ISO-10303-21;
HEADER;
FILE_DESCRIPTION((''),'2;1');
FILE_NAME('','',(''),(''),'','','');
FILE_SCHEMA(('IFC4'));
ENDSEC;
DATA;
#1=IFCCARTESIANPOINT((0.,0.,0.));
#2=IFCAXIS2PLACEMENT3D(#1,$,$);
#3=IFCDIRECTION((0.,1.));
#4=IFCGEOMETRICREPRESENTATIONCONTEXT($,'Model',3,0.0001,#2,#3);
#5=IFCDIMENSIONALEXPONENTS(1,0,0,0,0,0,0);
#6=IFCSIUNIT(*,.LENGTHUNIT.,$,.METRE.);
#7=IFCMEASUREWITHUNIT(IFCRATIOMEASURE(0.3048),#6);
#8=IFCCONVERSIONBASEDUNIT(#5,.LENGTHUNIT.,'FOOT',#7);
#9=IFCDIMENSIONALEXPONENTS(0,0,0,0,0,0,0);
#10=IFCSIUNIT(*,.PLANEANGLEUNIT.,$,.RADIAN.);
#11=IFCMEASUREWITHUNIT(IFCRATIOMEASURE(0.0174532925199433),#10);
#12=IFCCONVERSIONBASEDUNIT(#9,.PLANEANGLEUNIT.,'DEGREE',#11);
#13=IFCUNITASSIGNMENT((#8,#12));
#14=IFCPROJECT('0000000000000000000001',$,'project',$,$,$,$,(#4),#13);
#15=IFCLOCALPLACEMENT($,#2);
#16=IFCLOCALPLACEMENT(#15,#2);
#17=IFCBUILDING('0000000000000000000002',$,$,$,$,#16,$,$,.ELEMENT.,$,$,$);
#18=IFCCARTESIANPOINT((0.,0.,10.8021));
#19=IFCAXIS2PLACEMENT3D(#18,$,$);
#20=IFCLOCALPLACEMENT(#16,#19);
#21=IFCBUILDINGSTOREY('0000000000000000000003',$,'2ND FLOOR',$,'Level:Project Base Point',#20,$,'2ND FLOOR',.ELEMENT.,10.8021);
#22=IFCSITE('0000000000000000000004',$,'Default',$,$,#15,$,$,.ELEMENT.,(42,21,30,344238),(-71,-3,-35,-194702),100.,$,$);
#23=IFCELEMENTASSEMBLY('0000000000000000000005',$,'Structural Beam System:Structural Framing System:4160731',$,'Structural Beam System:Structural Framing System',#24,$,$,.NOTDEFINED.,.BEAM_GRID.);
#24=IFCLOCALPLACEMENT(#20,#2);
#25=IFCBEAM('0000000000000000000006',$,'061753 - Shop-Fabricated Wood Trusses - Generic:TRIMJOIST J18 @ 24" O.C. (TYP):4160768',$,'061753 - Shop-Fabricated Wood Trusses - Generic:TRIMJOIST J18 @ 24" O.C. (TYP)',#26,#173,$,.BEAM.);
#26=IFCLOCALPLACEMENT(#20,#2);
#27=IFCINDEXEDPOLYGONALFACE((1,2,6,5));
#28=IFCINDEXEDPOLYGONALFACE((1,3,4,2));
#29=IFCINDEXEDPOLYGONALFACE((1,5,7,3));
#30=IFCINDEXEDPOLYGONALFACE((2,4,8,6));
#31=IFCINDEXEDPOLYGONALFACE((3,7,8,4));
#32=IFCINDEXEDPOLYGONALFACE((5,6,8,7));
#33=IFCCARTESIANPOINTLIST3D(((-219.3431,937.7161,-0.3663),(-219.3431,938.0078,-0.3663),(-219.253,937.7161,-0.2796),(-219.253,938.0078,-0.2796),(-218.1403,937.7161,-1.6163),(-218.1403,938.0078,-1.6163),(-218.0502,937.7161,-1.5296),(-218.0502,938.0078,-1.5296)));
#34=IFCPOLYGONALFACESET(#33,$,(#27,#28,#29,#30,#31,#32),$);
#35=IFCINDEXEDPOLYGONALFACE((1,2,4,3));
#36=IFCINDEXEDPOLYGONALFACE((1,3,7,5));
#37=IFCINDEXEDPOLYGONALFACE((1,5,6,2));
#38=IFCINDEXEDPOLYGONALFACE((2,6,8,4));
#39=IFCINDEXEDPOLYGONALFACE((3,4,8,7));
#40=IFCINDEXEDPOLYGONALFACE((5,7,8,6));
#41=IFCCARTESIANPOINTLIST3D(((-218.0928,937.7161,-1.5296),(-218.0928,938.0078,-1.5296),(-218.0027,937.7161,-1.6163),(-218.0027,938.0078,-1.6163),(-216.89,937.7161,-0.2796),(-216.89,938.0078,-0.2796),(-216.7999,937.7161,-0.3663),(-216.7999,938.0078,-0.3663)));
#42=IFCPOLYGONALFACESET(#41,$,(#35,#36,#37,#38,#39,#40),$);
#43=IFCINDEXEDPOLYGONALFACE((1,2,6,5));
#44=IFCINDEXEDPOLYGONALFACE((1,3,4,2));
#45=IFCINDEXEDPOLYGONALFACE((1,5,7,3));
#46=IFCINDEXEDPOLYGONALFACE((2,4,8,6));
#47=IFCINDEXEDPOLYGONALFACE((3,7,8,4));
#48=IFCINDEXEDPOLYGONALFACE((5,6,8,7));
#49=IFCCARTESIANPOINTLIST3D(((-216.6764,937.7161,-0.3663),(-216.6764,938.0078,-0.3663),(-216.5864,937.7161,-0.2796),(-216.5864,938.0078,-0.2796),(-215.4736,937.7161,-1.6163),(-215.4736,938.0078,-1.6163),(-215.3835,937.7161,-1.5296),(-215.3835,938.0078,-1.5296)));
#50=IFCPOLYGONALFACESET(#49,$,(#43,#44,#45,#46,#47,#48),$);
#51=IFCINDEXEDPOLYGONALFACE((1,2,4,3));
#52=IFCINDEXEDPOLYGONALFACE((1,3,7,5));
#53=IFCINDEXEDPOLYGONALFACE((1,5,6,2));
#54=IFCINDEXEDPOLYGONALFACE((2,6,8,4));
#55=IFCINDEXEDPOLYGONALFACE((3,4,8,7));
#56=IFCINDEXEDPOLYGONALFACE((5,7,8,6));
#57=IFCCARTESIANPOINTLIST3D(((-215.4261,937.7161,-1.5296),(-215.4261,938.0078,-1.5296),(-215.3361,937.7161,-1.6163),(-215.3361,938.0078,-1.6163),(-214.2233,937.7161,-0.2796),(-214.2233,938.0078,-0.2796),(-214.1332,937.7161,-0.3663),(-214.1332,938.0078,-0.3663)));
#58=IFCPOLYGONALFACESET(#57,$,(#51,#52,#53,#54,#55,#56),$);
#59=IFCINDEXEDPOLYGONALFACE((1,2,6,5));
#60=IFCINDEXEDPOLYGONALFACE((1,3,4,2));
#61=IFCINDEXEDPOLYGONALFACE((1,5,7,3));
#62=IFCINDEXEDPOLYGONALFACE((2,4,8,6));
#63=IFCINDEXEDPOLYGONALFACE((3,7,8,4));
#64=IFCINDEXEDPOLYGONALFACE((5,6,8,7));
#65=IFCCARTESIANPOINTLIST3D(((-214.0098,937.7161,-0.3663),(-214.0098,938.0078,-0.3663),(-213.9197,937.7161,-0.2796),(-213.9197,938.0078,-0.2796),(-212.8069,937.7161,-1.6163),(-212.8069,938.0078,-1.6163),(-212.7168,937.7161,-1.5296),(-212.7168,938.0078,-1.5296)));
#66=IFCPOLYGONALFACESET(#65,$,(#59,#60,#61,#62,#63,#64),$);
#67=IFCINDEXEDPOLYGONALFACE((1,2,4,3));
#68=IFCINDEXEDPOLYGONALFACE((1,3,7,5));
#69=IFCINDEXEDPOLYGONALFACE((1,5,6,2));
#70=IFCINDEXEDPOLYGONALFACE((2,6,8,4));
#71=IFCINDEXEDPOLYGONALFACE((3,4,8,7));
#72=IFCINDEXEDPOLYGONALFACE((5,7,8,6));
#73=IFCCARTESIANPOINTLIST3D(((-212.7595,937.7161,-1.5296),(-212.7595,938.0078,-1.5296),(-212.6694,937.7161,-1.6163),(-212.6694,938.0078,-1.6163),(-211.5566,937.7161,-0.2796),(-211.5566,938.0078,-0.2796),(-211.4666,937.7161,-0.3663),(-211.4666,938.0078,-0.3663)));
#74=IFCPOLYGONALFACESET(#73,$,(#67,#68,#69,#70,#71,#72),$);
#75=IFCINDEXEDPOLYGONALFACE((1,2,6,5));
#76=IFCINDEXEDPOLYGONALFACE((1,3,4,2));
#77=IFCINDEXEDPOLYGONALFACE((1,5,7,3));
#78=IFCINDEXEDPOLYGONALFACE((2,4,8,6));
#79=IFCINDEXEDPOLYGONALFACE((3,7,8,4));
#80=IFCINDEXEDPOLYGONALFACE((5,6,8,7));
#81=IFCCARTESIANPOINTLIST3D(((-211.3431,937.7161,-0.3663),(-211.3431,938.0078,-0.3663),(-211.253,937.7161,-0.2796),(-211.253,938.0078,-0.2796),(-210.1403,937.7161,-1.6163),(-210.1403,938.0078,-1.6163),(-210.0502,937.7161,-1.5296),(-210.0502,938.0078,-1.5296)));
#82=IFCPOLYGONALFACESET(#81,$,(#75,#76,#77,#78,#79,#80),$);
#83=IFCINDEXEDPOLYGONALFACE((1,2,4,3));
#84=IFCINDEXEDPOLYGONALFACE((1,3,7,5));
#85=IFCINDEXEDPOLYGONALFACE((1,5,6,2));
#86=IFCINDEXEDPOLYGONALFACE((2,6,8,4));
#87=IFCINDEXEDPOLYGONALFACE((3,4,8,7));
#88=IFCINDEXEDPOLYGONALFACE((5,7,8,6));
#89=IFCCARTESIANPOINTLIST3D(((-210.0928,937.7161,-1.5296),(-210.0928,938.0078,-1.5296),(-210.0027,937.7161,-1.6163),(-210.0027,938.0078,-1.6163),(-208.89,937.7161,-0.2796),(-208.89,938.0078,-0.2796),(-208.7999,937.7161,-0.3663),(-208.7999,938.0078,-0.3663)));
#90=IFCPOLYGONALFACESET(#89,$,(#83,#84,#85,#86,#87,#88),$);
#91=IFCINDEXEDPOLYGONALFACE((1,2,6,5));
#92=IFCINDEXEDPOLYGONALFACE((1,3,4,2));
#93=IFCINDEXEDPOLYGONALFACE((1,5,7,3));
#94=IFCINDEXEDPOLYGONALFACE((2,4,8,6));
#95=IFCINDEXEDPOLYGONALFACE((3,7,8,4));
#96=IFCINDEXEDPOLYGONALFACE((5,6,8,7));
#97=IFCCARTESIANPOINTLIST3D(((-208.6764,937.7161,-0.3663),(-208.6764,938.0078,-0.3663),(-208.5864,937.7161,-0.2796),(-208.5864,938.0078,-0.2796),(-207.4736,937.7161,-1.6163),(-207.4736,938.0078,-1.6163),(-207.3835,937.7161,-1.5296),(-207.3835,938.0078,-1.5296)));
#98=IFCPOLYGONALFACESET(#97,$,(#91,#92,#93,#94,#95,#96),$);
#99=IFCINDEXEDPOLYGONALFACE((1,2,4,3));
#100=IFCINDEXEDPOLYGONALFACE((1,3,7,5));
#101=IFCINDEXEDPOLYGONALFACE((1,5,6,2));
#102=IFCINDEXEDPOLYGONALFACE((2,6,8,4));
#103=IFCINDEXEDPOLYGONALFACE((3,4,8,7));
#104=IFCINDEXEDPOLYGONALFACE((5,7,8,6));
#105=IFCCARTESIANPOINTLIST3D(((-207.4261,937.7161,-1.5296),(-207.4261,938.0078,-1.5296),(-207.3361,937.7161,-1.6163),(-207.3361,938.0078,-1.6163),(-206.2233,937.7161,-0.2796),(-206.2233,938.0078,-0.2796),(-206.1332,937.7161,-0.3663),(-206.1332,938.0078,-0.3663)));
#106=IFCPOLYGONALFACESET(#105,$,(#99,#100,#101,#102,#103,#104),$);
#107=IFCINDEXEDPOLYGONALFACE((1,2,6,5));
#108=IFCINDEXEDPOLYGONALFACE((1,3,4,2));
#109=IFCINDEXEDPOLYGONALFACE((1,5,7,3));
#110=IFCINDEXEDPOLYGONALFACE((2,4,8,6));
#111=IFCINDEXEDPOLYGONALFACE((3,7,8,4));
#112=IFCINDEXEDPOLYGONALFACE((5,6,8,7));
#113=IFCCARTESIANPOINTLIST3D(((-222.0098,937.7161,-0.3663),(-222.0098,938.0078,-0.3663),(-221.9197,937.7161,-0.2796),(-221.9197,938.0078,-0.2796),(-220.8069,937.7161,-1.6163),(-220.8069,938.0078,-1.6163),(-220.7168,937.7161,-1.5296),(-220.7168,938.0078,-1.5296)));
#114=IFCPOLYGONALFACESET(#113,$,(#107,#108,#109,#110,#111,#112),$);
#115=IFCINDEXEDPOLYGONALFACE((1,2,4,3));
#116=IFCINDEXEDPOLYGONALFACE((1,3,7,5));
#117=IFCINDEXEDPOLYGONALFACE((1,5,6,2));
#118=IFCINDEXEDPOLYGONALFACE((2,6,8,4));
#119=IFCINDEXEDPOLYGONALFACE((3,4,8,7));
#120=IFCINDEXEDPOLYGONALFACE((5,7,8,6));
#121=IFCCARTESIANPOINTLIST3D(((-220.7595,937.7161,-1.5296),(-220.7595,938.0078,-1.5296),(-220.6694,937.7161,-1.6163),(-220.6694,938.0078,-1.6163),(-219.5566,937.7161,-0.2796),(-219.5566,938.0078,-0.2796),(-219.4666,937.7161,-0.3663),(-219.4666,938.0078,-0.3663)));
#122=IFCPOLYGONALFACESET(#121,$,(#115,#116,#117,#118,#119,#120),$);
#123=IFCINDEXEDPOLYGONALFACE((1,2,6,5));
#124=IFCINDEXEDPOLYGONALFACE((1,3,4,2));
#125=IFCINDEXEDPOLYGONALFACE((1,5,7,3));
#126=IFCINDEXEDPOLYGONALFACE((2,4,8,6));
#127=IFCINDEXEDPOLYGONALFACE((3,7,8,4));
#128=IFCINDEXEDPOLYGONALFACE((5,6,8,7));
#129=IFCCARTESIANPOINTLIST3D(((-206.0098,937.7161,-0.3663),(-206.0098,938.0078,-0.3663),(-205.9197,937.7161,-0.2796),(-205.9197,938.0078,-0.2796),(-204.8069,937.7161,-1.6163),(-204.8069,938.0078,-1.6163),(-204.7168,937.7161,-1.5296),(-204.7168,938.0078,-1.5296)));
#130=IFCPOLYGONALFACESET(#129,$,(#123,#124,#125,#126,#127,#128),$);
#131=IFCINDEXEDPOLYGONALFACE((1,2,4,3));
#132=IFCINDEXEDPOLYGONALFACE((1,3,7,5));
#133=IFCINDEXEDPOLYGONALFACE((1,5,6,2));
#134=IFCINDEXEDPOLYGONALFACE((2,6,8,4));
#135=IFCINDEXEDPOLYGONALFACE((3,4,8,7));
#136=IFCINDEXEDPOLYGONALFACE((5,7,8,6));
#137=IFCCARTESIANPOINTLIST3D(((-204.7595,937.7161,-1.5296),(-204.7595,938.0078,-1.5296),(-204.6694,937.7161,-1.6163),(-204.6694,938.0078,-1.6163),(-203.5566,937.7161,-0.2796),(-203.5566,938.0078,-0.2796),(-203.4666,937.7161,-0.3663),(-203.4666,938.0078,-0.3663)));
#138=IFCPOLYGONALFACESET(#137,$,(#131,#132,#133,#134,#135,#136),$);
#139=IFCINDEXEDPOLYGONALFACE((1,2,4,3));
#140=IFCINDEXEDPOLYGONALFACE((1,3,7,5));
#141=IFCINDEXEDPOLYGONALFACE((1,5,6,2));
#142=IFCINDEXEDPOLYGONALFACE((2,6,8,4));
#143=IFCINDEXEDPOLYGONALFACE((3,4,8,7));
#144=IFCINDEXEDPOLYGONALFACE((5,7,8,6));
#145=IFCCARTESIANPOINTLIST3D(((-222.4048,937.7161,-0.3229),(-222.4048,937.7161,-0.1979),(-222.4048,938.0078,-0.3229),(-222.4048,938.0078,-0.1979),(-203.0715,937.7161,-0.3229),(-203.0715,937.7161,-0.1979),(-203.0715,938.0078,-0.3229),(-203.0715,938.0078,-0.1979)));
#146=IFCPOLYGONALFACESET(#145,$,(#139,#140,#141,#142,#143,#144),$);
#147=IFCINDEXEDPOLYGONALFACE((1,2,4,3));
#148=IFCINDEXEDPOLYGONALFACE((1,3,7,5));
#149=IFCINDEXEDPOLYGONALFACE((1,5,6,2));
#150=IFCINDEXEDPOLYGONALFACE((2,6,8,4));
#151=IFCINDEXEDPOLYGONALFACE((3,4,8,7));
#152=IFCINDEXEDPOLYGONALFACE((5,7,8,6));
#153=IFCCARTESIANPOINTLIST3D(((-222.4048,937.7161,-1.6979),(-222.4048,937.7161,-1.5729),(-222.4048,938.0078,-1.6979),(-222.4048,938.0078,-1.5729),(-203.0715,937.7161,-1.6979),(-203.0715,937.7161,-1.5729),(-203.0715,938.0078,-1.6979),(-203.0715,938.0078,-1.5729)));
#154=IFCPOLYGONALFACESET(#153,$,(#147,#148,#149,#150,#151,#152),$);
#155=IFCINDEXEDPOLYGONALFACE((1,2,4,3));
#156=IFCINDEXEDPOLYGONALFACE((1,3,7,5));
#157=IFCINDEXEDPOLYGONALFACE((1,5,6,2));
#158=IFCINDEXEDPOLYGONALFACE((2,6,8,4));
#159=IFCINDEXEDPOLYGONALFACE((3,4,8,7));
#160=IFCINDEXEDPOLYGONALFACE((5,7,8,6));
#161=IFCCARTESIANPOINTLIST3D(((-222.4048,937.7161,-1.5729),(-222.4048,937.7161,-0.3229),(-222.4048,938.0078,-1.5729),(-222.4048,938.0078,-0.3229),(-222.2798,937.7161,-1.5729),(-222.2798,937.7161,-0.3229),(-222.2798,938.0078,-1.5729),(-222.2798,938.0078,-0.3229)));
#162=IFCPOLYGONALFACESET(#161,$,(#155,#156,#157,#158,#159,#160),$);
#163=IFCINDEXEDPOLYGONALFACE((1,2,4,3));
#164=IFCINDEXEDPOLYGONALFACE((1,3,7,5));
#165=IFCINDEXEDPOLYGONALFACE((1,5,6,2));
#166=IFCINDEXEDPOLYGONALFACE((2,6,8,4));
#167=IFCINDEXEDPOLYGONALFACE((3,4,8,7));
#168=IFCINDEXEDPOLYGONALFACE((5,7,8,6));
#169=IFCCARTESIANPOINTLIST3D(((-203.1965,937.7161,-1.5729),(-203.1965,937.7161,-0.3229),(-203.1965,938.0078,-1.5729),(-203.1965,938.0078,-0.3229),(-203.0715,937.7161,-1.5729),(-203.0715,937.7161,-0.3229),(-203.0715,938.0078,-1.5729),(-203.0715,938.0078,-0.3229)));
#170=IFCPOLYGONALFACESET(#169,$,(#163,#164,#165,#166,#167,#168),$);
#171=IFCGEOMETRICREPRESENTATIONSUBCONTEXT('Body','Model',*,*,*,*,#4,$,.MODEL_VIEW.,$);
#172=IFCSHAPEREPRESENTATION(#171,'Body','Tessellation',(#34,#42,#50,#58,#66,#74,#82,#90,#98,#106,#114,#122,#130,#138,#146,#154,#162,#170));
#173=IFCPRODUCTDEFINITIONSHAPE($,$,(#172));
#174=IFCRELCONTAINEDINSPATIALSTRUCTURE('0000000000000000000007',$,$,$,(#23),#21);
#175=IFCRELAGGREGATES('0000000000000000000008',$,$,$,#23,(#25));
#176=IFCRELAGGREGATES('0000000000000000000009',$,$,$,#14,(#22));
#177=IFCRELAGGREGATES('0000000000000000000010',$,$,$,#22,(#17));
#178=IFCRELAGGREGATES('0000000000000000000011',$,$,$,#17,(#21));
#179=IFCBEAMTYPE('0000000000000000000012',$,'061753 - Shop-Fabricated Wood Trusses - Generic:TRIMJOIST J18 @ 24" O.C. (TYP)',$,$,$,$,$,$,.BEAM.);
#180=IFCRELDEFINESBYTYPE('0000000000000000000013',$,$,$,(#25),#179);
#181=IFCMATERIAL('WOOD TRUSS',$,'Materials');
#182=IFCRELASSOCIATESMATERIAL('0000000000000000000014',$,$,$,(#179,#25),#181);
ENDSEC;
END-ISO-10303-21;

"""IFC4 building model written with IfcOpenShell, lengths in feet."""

from ifc_helpers import new_model, entity, si_unit, converted_unit, direction, frame, frame_2d, origin, origin_2d_with_axis, place, context, subcontext, project, spatial, rectangle, extrude, source, transform, mapped, material, material_profile, profile_set, profile_usage, type_object, type_shapes, element, aggregate, save


model = new_model("IFC4")

# Units and contexts
model_context = context("Model", 3, precision=0.0001, world=origin(), true_north=direction((0.0, 1.0)))
body_context = subcontext(model_context, "Body", "Model", "MODEL_VIEW")
ifc_project = project(units=[converted_unit("LENGTHUNIT", "FOOT", entity("IfcRatioMeasure", 0.3048), si_unit("LENGTHUNIT", "METRE"), dimensions=[1, 0, 0, 0, 0, 0, 0]), converted_unit("PLANEANGLEUNIT", "DEGREE", entity("IfcRatioMeasure", 0.0174532925199433), si_unit("PLANEANGLEUNIT", "RADIAN"), dimensions=[0, 0, 0, 0, 0, 0, 0])], contexts=[model_context])

# Site, building, storey
site_placement = place(None, origin())
site = spatial("IfcSite", under=ifc_project, at=site_placement, Name="Default", CompositionType="ELEMENT", RefLatitude=(42, 21, 30, 344238), RefLongitude=(-71, -3, -35, -194702), RefElevation=100.0)
building_placement = place(site_placement, origin())
building = spatial("IfcBuilding", under=site, at=building_placement, CompositionType="ELEMENT")
storey_placement = place(building_placement, frame((0.0, 0.0, 10.8021)))
storey = spatial("IfcBuildingStorey", under=building, at=storey_placement, Name="2ND FLOOR", ObjectType="Level:Project Base Point", LongName="2ND FLOOR", CompositionType="ELEMENT", Elevation=10.8021)

# Element assembly, beam
ifc_material_1 = material(Name="WOOD TRUSS", Category="Materials")
ifc_material_profile_1 = material_profile(ifc_material_1, rectangle(XDim=1.7347, YDim=0.125, at=frame_2d((0.0, 0.0), x_axis=(1.0, 0.0))), Name="TRIMJOIST J18 @ 24\" O.C. (TYP)")
ifc_material_profile_2 = material_profile(ifc_material_1, rectangle(XDim=1.7347, YDim=0.125, at=frame_2d((0.0, 0.0), x_axis=(1.0, 0.0))), Name="TRIMJOIST J18 @ 24\" O.C. (TYP)")
ifc_material_profile_3 = material_profile(ifc_material_1, rectangle(XDim=1.7347, YDim=0.125, at=frame_2d((0.0, 0.0), x_axis=(1.0, 0.0))), Name="TRIMJOIST J18 @ 24\" O.C. (TYP)")
ifc_material_profile_4 = material_profile(ifc_material_1, rectangle(XDim=1.7347, YDim=0.125, at=frame_2d((0.0, 0.0), x_axis=(1.0, 0.0))), Name="TRIMJOIST J18 @ 24\" O.C. (TYP)")
ifc_material_profile_5 = material_profile(ifc_material_1, rectangle(XDim=1.7347, YDim=0.125, at=frame_2d((0.0, 0.0), x_axis=(1.0, 0.0))), Name="TRIMJOIST J18 @ 24\" O.C. (TYP)")
ifc_material_profile_6 = material_profile(ifc_material_1, rectangle(XDim=1.7347, YDim=0.125, at=frame_2d((0.0, 0.0), x_axis=(1.0, 0.0))), Name="TRIMJOIST J18 @ 24\" O.C. (TYP)")
ifc_material_profile_7 = material_profile(ifc_material_1, rectangle(XDim=1.7347, YDim=0.125, at=frame_2d((0.0, 0.0), x_axis=(1.0, 0.0))), Name="TRIMJOIST J18 @ 24\" O.C. (TYP)")
ifc_material_profile_8 = material_profile(ifc_material_1, rectangle(XDim=1.7347, YDim=0.125, at=frame_2d((0.0, 0.0), x_axis=(1.0, 0.0))), Name="TRIMJOIST J18 @ 24\" O.C. (TYP)")
ifc_material_profile_9 = material_profile(ifc_material_1, rectangle(XDim=1.7347, YDim=0.125, at=frame_2d((0.0, 0.0), x_axis=(1.0, 0.0))), Name="TRIMJOIST J18 @ 24\" O.C. (TYP)")
ifc_material_profile_10 = material_profile(ifc_material_1, rectangle(XDim=1.7347, YDim=0.125, at=origin_2d_with_axis()), Name="TRIMJOIST J18 @ 24\" O.C. (TYP)")
ifc_material_profile_11 = material_profile(ifc_material_1, rectangle(XDim=0.125, YDim=0.2917, at=origin_2d_with_axis()), Name="TRIMJOIST J18 @ 24\" O.C. (TYP)")
ifc_material_profile_12 = material_profile(ifc_material_1, rectangle(XDim=0.125, YDim=0.2917, at=origin_2d_with_axis()), Name="TRIMJOIST J18 @ 24\" O.C. (TYP)")
ifc_material_profile_13 = material_profile(ifc_material_1, rectangle(XDim=1.25, YDim=0.2917, at=origin_2d_with_axis()), Name="TRIMJOIST J18 @ 24\" O.C. (TYP)")
ifc_material_profile_14 = material_profile(ifc_material_1, rectangle(XDim=1.25, YDim=0.2917, at=origin_2d_with_axis()), Name="TRIMJOIST J18 @ 24\" O.C. (TYP)")
ifc_profile_set_1 = profile_set([ifc_material_profile_1, ifc_material_profile_2, ifc_material_profile_3, ifc_material_profile_4, ifc_material_profile_5, ifc_material_profile_6, ifc_material_profile_7, ifc_material_profile_8, ifc_material_profile_9, ifc_material_profile_10, ifc_material_profile_11, ifc_material_profile_12, ifc_material_profile_13, ifc_material_profile_14], Name="TRIMJOIST J18 @ 24\" O.C. (TYP)")
beam_type_1 = type_object("IfcBeamType", Name="061753 - Shop-Fabricated Wood Trusses - Generic:TRIMJOIST J18 @ 24\" O.C. (TYP)", PredefinedType="BEAM", material=ifc_profile_set_1)
shared_shape_1 = source(origin(), body_context, "Body", "SweptSolid", [
    extrude(rectangle(XDim=1.7347, YDim=0.125, at=frame_2d((0.0, 0.0), x_axis=(1.0, 0.0))), frame((5.9585, -0.1458, 0.0), z_axis=(0.0, 1.0, 0.0), x_axis=(0.693383, 0.0, 0.720569)), (0.0, 0.0, 1.0), 0.2917),
    extrude(rectangle(XDim=1.7347, YDim=0.125, at=origin_2d_with_axis()), frame((4.7082, -0.1458, 0.0), z_axis=(0.0, 1.0, 0.0), x_axis=(0.693383, 0.0, -0.720569)), (0.0, 0.0, 1.0), 0.2917),
    extrude(rectangle(XDim=1.7347, YDim=0.125, at=frame_2d((0.0, 0.0), x_axis=(1.0, 0.0))), frame((3.2918, -0.1458, 0.0), z_axis=(0.0, 1.0, 0.0), x_axis=(0.693383, 0.0, 0.720569)), (0.0, 0.0, 1.0), 0.2917),
    extrude(rectangle(XDim=1.7347, YDim=0.125, at=frame_2d((0.0, 0.0), x_axis=(1.0, 0.0))), frame((2.0415, -0.1458, 0.0), z_axis=(0.0, 1.0, 0.0), x_axis=(0.693383, 0.0, -0.720569)), (0.0, 0.0, 1.0), 0.2917),
    extrude(rectangle(XDim=1.7347, YDim=0.125, at=frame_2d((0.0, 0.0), x_axis=(1.0, 0.0))), frame((0.6251, -0.1458, 0.0), z_axis=(0.0, 1.0, 0.0), x_axis=(0.693383, 0.0, 0.720569)), (0.0, 0.0, 1.0), 0.2917),
    extrude(rectangle(XDim=1.7347, YDim=0.125, at=frame_2d((0.0, 0.0), x_axis=(1.0, 0.0))), frame((-0.6251, -0.1458, 0.0), z_axis=(0.0, 1.0, 0.0), x_axis=(0.693383, 0.0, -0.720569)), (0.0, 0.0, 1.0), 0.2917),
    extrude(rectangle(XDim=1.7347, YDim=0.125, at=frame_2d((0.0, 0.0), x_axis=(1.0, 0.0))), frame((-2.0415, -0.1458, 0.0), z_axis=(0.0, 1.0, 0.0), x_axis=(0.693383, 0.0, 0.720569)), (0.0, 0.0, 1.0), 0.2917),
    extrude(rectangle(XDim=1.7347, YDim=0.125, at=origin_2d_with_axis()), frame((-3.2918, -0.1458, 0.0), z_axis=(0.0, 1.0, 0.0), x_axis=(0.693383, 0.0, -0.720569)), (0.0, 0.0, 1.0), 0.2917),
    extrude(rectangle(XDim=1.7347, YDim=0.125, at=frame_2d((0.0, 0.0), x_axis=(1.0, 0.0))), frame((-4.7082, -0.1458, 0.0), z_axis=(0.0, 1.0, 0.0), x_axis=(0.693383, 0.0, 0.720569)), (0.0, 0.0, 1.0), 0.2917),
    extrude(rectangle(XDim=1.7347, YDim=0.125, at=frame_2d((0.0, 0.0), x_axis=(1.0, 0.0))), frame((-5.9585, -0.1458, 0.0), z_axis=(0.0, 1.0, 0.0), x_axis=(0.693383, 0.0, -0.720569)), (0.0, 0.0, 1.0), 0.2917),
    extrude(rectangle(XDim=1.7347, YDim=0.125, at=frame_2d((0.0, 0.0), x_axis=(1.0, 0.0))), frame((8.6251, -0.1458, 0.0), z_axis=(0.0, 1.0, 0.0), x_axis=(0.693383, 0.0, 0.720569)), (0.0, 0.0, 1.0), 0.2917),
    extrude(rectangle(XDim=1.7347, YDim=0.125, at=origin_2d_with_axis()), frame((7.3749, -0.1458, 0.0), z_axis=(0.0, 1.0, 0.0), x_axis=(0.693383, 0.0, -0.720569)), (0.0, 0.0, 1.0), 0.2917),
    extrude(rectangle(XDim=1.7347, YDim=0.125, at=frame_2d((0.0, 0.0), x_axis=(1.0, 0.0))), frame((-7.3749, -0.1458, 0.0), z_axis=(0.0, 1.0, 0.0), x_axis=(0.693383, 0.0, 0.720569)), (0.0, 0.0, 1.0), 0.2917),
    extrude(rectangle(XDim=1.7347, YDim=0.125, at=origin_2d_with_axis()), frame((-8.6251, -0.1458, 0.0), z_axis=(0.0, 1.0, 0.0), x_axis=(0.693383, 0.0, -0.720569)), (0.0, 0.0, 1.0), 0.2917),
    extrude(rectangle(XDim=0.125, YDim=0.2917, at=origin_2d_with_axis()), frame((-9.6667, 0.0, 0.6875), z_axis=(1.0, 0.0, 0.0), x_axis=(0.0, 0.0, -1.0)), (0.0, 0.0, 1.0), 19.3333),
    extrude(rectangle(XDim=0.125, YDim=0.2917, at=origin_2d_with_axis()), frame((-9.6667, 0.0, -0.6875), z_axis=(1.0, 0.0, 0.0), x_axis=(0.0, 0.0, -1.0)), (0.0, 0.0, 1.0), 19.3333),
    extrude(rectangle(XDim=1.25, YDim=0.2917, at=origin_2d_with_axis()), frame((9.5417, 0.0, 0.0), z_axis=(1.0, 0.0, 0.0), x_axis=(0.0, 0.0, -1.0)), (0.0, 0.0, 1.0), 0.125),
    extrude(rectangle(XDim=1.25, YDim=0.2917, at=origin_2d_with_axis()), frame((-9.6667, 0.0, 0.0), z_axis=(1.0, 0.0, 0.0), x_axis=(0.0, 0.0, -1.0)), (0.0, 0.0, 1.0), 0.125),
])
type_shapes(beam_type_1, [shared_shape_1])
assembly_1_placement = place(storey_placement, origin())
assembly_1 = element("IfcElementAssembly", 1, at=assembly_1_placement, inside=storey, Name="Structural Beam System:Structural Framing System:4160731", ObjectType="Structural Beam System:Structural Framing System", AssemblyPlace="NOTDEFINED", PredefinedType="BEAM_GRID")
ifc_profile_usage_1 = profile_usage(ifc_profile_set_1, cardinal=8)
beam_1_placement = place(assembly_1_placement, frame((-212.7382, 937.8619, -0.9479), z_axis=(0.0, 0.0, 1.0), x_axis=(-1.0, 0.0, 0.0)))
beam_1 = element("IfcBeam", 2, at=beam_1_placement, type_object=beam_type_1, material=ifc_profile_usage_1, Name="061753 - Shop-Fabricated Wood Trusses - Generic:TRIMJOIST J18 @ 24\" O.C. (TYP):4160768", ObjectType="061753 - Shop-Fabricated Wood Trusses - Generic:TRIMJOIST J18 @ 24\" O.C. (TYP)", PredefinedType="BEAM", context=body_context, shape_type="MappedRepresentation", body=[
    mapped(shared_shape_1, transform((0.0, 0.0, 0.0), scale=1.0)),
])
aggregate(assembly_1, [beam_1])

save(model, "model.ifc")
